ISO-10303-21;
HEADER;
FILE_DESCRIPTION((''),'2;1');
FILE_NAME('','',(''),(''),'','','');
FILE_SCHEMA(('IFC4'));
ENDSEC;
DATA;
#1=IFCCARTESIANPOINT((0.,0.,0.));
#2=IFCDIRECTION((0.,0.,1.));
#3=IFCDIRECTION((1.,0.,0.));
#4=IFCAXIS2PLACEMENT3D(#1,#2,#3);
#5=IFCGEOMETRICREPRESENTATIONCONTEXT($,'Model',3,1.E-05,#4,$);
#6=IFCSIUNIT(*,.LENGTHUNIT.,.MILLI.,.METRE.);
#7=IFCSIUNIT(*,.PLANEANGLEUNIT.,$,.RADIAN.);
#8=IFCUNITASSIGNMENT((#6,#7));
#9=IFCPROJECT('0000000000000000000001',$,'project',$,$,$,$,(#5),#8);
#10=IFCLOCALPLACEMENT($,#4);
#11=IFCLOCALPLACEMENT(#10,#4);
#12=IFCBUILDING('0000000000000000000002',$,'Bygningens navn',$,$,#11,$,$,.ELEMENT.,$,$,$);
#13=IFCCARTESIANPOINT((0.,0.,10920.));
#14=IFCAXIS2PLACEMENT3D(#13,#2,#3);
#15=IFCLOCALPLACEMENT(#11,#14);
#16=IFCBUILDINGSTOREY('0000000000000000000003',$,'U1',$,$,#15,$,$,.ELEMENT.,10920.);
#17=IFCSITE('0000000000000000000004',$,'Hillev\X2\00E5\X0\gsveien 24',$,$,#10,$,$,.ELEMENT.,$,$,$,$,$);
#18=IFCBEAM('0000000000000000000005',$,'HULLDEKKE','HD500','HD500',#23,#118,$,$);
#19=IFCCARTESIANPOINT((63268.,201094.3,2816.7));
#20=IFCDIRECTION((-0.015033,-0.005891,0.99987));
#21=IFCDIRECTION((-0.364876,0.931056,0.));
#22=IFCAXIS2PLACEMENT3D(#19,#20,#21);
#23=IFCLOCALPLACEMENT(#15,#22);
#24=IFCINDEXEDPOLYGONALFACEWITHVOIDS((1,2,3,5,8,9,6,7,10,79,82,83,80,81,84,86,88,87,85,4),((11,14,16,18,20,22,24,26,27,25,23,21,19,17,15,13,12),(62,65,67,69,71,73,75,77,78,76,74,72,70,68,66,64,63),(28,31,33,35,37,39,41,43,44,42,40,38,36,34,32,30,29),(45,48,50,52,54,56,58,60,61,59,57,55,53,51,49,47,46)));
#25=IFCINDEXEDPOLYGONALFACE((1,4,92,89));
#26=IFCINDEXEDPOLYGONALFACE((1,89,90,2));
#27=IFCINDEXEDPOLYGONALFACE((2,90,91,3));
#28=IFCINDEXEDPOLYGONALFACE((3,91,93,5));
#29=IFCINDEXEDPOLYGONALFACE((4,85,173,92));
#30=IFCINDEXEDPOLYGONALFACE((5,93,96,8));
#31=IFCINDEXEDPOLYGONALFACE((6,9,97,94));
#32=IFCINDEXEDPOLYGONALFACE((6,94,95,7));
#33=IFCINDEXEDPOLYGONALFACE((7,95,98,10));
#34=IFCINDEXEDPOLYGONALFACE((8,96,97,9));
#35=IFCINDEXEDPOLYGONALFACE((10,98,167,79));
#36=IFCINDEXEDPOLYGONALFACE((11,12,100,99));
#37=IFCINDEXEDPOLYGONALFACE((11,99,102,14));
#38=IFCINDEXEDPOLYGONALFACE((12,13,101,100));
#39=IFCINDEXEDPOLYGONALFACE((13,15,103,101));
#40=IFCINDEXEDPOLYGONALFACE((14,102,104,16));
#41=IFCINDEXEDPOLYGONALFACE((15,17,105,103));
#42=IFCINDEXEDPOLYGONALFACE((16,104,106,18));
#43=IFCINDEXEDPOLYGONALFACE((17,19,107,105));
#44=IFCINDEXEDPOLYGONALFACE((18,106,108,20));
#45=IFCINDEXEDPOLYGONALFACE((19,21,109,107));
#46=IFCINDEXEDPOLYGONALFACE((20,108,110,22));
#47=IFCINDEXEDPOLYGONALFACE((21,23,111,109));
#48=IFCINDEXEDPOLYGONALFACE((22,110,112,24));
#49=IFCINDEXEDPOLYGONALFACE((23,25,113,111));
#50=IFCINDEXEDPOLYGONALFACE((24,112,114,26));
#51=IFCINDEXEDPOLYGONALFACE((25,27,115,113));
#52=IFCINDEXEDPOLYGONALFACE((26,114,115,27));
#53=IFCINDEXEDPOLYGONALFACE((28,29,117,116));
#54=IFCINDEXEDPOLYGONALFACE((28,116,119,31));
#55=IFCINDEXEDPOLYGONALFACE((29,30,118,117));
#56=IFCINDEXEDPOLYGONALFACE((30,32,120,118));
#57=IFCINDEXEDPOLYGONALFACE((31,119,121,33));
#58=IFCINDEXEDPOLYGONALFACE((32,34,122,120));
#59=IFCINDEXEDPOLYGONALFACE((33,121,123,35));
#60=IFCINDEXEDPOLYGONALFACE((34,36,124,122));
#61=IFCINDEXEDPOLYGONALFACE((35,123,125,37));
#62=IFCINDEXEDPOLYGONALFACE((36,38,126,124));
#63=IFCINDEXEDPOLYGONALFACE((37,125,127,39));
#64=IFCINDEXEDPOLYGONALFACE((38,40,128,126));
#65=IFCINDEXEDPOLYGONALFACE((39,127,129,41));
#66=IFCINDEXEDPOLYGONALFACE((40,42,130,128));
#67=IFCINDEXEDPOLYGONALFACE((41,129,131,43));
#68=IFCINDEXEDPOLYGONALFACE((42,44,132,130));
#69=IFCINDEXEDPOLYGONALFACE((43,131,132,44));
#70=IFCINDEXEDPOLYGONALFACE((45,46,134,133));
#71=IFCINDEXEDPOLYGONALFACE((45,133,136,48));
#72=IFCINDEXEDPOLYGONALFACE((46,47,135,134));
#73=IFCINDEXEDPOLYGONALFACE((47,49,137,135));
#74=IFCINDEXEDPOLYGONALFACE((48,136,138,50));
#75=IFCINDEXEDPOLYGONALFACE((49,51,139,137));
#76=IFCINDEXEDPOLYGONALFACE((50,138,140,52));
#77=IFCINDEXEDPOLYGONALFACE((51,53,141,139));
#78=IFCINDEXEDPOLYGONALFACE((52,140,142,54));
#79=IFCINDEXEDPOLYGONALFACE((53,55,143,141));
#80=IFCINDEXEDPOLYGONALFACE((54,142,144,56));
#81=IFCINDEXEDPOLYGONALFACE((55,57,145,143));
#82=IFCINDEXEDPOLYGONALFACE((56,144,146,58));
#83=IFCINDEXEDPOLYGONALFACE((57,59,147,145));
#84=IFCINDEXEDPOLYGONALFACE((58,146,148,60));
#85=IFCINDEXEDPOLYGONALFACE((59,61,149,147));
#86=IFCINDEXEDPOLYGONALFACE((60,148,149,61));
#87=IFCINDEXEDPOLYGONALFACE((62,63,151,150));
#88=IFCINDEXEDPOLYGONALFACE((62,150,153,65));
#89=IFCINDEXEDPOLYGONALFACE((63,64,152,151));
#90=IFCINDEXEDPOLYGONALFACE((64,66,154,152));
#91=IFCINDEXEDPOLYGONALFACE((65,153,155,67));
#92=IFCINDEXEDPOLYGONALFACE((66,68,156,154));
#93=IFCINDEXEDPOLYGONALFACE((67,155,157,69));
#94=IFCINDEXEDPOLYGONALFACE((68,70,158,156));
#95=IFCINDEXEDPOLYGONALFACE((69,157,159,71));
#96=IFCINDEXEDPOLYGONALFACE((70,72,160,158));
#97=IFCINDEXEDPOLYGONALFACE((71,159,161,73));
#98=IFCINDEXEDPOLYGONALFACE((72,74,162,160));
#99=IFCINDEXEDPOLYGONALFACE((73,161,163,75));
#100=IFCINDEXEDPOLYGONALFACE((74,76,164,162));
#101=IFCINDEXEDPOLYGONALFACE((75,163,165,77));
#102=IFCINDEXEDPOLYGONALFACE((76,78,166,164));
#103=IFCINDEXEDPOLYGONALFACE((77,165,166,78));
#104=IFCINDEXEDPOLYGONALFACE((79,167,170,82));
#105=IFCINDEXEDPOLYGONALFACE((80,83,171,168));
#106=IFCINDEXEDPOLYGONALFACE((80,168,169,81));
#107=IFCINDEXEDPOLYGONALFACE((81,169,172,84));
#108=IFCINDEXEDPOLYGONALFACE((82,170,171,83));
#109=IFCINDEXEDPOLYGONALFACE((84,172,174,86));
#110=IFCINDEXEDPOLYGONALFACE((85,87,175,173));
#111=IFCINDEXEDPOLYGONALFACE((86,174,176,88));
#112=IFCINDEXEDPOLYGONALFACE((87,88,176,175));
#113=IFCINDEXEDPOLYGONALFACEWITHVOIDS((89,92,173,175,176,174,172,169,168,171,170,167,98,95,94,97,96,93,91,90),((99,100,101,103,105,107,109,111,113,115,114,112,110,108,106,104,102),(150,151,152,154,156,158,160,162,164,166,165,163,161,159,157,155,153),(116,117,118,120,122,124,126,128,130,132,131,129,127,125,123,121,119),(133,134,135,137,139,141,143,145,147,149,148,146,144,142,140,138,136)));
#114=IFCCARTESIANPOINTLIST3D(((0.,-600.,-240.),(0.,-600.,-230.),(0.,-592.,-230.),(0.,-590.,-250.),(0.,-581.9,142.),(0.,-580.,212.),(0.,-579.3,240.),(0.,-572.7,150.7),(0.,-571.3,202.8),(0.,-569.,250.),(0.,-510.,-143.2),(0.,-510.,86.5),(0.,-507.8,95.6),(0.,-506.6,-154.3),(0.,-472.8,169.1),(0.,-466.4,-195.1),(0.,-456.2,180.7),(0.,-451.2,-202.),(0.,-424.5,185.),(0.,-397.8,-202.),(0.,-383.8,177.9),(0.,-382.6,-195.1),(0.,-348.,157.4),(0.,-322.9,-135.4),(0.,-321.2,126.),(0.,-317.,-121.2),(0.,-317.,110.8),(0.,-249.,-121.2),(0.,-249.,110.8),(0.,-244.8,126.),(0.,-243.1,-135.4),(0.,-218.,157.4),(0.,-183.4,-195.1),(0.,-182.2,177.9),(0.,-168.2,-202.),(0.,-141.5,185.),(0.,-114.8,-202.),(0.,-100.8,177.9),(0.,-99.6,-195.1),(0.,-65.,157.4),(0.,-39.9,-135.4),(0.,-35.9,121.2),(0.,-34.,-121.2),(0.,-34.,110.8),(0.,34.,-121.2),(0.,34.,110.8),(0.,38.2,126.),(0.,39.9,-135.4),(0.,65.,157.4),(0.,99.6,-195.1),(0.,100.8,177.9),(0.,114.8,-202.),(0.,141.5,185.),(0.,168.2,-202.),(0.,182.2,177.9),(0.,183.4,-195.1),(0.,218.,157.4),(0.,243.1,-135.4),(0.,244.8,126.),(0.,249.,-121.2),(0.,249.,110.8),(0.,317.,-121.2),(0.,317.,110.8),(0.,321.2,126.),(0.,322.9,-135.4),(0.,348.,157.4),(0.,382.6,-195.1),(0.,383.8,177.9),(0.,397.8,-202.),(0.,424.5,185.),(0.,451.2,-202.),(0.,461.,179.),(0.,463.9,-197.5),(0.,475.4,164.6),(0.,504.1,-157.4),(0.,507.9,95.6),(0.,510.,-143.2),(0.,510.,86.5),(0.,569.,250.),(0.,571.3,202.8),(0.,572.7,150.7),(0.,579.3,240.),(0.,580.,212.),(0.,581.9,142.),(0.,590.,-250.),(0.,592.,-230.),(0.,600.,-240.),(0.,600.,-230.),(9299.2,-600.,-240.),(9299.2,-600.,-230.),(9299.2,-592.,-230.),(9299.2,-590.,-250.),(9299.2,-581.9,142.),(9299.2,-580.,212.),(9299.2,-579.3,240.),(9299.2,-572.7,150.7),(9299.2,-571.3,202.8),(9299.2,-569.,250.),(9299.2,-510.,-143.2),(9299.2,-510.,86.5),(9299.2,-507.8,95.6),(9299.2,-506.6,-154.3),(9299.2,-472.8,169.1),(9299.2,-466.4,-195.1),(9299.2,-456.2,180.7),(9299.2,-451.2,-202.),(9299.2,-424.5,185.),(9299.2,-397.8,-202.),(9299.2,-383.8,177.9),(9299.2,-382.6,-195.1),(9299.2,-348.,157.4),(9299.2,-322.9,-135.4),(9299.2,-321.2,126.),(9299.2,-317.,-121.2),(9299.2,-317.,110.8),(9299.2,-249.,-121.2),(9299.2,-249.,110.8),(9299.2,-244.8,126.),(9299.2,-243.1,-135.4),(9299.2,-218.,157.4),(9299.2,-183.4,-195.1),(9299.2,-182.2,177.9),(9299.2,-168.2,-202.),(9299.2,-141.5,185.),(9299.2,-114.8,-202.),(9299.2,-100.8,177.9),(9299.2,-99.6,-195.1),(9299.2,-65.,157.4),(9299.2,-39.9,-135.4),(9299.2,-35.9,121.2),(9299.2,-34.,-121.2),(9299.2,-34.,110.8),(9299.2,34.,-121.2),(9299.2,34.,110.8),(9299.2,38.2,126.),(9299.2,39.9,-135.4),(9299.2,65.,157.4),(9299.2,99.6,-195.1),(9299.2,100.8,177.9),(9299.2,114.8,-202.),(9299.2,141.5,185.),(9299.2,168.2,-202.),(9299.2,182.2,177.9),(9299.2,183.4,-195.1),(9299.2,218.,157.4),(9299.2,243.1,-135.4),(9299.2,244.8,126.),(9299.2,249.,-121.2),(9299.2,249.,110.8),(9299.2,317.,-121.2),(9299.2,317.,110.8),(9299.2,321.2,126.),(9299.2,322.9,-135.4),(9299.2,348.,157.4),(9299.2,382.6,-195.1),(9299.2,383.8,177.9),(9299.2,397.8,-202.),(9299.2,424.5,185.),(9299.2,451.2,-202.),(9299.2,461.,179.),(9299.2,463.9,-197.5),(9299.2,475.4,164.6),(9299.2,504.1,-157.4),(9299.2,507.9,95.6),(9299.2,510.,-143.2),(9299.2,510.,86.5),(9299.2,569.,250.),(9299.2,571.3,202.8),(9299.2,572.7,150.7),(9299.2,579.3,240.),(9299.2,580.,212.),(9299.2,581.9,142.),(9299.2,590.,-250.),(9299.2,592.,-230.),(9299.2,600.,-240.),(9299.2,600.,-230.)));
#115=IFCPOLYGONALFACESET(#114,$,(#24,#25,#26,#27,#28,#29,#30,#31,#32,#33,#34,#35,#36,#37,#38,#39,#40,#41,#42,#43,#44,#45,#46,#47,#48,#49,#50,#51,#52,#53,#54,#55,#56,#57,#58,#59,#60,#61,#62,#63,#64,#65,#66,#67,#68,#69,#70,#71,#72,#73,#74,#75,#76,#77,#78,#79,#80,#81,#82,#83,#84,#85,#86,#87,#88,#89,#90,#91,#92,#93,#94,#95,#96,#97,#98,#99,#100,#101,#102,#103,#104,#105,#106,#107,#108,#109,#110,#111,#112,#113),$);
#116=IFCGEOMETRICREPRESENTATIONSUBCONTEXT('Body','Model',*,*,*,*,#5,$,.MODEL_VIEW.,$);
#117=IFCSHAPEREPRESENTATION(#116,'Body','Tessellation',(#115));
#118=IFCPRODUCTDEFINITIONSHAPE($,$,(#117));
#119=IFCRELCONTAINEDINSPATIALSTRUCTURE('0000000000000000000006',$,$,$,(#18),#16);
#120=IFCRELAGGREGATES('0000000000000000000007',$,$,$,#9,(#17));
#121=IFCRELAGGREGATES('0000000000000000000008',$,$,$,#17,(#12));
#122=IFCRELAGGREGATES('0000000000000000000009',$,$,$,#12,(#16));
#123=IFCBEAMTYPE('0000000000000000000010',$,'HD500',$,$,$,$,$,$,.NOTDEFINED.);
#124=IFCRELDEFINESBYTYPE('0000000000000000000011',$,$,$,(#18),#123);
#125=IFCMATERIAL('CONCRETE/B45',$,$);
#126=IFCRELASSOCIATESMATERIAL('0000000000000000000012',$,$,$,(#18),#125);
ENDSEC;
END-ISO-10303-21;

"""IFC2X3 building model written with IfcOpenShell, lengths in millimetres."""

from ifc_helpers import new_model, si_unit, frame, origin_with_axes, place, context, subcontext, project, spatial, polyline, outline, extrude, material, type_object, element, save


model = new_model("IFC2X3")

# Units and contexts
model_context = context("Model", 3, precision=1e-05, world=origin_with_axes())
body_context = subcontext(model_context, "Body", "Model", "MODEL_VIEW")
ifc_project = project(units=[si_unit("LENGTHUNIT", "METRE", prefix="MILLI"), si_unit("PLANEANGLEUNIT", "RADIAN")], contexts=[model_context])

# Site, building, storey
site_placement = place(None, origin_with_axes())
site = spatial("IfcSite", under=ifc_project, at=site_placement, Name="Hillevågsveien 24", CompositionType="ELEMENT")
building_placement = place(site_placement, origin_with_axes())
building = spatial("IfcBuilding", under=site, at=building_placement, Name="Bygningens navn", CompositionType="ELEMENT")
storey_placement = place(building_placement, frame((0.0, 0.0, 10920.0), z_axis=(0.0, 0.0, 1.0), x_axis=(1.0, 0.0, 0.0)))
storey = spatial("IfcBuildingStorey", under=building, at=storey_placement, Name="U1", CompositionType="ELEMENT", Elevation=10920.0)

# Beam
ifc_material_1 = material(Name="CONCRETE/B45")
beam_type_1 = type_object("IfcBeamType", Name="HD500", PredefinedType="NOTDEFINED")
beam_1_placement = place(storey_placement, frame((63268.0, 201094.3, 2816.7), z_axis=(-0.015033, -0.005891, 0.99987), x_axis=(-0.364876, 0.931056, 0.0)))
element("IfcBeam", 1, at=beam_1_placement, inside=storey, type_object=beam_type_1, material=ifc_material_1, Name="HULLDEKKE", Description="HD500", ObjectType="HD500", context=body_context, shape_type="SweptSolid", body=[
    extrude(outline(polyline([(581.9, 142.0), (592.0, -230.0), (600.0, -230.0), (600.0, -240.0), (590.0, -250.0), (-590.0, -250.0), (-600.0, -240.0), (-600.0, -230.0), (-592.0, -230.0), (-581.9, 142.0), (-572.7, 150.7), (-571.3, 202.8), (-580.0, 212.0), (-579.3, 240.0), (-569.0, 250.0), (569.0, 250.0), (579.3, 240.0), (580.0, 212.0), (571.3, 202.8), (572.7, 150.7), (581.9, 142.0)]), holes=[polyline([(466.4, -195.1), (506.6, -154.3), (510.0, -143.2), (510.0, 86.5), (507.8, 95.6), (472.8, 169.1), (456.2, 180.7), (424.5, 185.0), (383.8, 177.9), (348.0, 157.4), (321.2, 126.0), (317.0, 110.8), (317.0, -121.2), (322.9, -135.4), (382.6, -195.1), (397.8, -202.0), (451.2, -202.0), (466.4, -195.1)]), polyline([(183.4, -195.1), (243.1, -135.4), (249.0, -121.2), (249.0, 110.8), (244.8, 126.0), (218.0, 157.4), (182.2, 177.9), (141.5, 185.0), (100.8, 177.9), (65.0, 157.4), (35.9, 121.2), (34.0, 110.8), (34.0, -121.2), (39.9, -135.4), (99.6, -195.1), (114.8, -202.0), (168.2, -202.0), (183.4, -195.1)]), polyline([(-99.6, -195.1), (-39.9, -135.4), (-34.0, -121.2), (-34.0, 110.8), (-38.2, 126.0), (-65.0, 157.4), (-100.8, 177.9), (-141.5, 185.0), (-182.2, 177.9), (-218.0, 157.4), (-244.8, 126.0), (-249.0, 110.8), (-249.0, -121.2), (-243.1, -135.4), (-183.4, -195.1), (-168.2, -202.0), (-114.8, -202.0), (-99.6, -195.1)]), polyline([(-382.6, -195.1), (-322.9, -135.4), (-317.0, -121.2), (-317.0, 110.8), (-321.2, 126.0), (-348.0, 157.4), (-383.8, 177.9), (-424.5, 185.0), (-461.0, 179.0), (-475.4, 164.6), (-507.9, 95.6), (-510.0, 86.5), (-510.0, -143.2), (-504.1, -157.4), (-463.9, -197.5), (-451.2, -202.0), (-397.8, -202.0), (-382.6, -195.1)])]), frame((9299.2, 0.0, 0.0), z_axis=(-1.0, 0.0, 0.0), x_axis=(0.0, -1.0, 0.0)), (0.0, 0.0, 1.0), 9299.2),
])

save(model, "model.ifc")
